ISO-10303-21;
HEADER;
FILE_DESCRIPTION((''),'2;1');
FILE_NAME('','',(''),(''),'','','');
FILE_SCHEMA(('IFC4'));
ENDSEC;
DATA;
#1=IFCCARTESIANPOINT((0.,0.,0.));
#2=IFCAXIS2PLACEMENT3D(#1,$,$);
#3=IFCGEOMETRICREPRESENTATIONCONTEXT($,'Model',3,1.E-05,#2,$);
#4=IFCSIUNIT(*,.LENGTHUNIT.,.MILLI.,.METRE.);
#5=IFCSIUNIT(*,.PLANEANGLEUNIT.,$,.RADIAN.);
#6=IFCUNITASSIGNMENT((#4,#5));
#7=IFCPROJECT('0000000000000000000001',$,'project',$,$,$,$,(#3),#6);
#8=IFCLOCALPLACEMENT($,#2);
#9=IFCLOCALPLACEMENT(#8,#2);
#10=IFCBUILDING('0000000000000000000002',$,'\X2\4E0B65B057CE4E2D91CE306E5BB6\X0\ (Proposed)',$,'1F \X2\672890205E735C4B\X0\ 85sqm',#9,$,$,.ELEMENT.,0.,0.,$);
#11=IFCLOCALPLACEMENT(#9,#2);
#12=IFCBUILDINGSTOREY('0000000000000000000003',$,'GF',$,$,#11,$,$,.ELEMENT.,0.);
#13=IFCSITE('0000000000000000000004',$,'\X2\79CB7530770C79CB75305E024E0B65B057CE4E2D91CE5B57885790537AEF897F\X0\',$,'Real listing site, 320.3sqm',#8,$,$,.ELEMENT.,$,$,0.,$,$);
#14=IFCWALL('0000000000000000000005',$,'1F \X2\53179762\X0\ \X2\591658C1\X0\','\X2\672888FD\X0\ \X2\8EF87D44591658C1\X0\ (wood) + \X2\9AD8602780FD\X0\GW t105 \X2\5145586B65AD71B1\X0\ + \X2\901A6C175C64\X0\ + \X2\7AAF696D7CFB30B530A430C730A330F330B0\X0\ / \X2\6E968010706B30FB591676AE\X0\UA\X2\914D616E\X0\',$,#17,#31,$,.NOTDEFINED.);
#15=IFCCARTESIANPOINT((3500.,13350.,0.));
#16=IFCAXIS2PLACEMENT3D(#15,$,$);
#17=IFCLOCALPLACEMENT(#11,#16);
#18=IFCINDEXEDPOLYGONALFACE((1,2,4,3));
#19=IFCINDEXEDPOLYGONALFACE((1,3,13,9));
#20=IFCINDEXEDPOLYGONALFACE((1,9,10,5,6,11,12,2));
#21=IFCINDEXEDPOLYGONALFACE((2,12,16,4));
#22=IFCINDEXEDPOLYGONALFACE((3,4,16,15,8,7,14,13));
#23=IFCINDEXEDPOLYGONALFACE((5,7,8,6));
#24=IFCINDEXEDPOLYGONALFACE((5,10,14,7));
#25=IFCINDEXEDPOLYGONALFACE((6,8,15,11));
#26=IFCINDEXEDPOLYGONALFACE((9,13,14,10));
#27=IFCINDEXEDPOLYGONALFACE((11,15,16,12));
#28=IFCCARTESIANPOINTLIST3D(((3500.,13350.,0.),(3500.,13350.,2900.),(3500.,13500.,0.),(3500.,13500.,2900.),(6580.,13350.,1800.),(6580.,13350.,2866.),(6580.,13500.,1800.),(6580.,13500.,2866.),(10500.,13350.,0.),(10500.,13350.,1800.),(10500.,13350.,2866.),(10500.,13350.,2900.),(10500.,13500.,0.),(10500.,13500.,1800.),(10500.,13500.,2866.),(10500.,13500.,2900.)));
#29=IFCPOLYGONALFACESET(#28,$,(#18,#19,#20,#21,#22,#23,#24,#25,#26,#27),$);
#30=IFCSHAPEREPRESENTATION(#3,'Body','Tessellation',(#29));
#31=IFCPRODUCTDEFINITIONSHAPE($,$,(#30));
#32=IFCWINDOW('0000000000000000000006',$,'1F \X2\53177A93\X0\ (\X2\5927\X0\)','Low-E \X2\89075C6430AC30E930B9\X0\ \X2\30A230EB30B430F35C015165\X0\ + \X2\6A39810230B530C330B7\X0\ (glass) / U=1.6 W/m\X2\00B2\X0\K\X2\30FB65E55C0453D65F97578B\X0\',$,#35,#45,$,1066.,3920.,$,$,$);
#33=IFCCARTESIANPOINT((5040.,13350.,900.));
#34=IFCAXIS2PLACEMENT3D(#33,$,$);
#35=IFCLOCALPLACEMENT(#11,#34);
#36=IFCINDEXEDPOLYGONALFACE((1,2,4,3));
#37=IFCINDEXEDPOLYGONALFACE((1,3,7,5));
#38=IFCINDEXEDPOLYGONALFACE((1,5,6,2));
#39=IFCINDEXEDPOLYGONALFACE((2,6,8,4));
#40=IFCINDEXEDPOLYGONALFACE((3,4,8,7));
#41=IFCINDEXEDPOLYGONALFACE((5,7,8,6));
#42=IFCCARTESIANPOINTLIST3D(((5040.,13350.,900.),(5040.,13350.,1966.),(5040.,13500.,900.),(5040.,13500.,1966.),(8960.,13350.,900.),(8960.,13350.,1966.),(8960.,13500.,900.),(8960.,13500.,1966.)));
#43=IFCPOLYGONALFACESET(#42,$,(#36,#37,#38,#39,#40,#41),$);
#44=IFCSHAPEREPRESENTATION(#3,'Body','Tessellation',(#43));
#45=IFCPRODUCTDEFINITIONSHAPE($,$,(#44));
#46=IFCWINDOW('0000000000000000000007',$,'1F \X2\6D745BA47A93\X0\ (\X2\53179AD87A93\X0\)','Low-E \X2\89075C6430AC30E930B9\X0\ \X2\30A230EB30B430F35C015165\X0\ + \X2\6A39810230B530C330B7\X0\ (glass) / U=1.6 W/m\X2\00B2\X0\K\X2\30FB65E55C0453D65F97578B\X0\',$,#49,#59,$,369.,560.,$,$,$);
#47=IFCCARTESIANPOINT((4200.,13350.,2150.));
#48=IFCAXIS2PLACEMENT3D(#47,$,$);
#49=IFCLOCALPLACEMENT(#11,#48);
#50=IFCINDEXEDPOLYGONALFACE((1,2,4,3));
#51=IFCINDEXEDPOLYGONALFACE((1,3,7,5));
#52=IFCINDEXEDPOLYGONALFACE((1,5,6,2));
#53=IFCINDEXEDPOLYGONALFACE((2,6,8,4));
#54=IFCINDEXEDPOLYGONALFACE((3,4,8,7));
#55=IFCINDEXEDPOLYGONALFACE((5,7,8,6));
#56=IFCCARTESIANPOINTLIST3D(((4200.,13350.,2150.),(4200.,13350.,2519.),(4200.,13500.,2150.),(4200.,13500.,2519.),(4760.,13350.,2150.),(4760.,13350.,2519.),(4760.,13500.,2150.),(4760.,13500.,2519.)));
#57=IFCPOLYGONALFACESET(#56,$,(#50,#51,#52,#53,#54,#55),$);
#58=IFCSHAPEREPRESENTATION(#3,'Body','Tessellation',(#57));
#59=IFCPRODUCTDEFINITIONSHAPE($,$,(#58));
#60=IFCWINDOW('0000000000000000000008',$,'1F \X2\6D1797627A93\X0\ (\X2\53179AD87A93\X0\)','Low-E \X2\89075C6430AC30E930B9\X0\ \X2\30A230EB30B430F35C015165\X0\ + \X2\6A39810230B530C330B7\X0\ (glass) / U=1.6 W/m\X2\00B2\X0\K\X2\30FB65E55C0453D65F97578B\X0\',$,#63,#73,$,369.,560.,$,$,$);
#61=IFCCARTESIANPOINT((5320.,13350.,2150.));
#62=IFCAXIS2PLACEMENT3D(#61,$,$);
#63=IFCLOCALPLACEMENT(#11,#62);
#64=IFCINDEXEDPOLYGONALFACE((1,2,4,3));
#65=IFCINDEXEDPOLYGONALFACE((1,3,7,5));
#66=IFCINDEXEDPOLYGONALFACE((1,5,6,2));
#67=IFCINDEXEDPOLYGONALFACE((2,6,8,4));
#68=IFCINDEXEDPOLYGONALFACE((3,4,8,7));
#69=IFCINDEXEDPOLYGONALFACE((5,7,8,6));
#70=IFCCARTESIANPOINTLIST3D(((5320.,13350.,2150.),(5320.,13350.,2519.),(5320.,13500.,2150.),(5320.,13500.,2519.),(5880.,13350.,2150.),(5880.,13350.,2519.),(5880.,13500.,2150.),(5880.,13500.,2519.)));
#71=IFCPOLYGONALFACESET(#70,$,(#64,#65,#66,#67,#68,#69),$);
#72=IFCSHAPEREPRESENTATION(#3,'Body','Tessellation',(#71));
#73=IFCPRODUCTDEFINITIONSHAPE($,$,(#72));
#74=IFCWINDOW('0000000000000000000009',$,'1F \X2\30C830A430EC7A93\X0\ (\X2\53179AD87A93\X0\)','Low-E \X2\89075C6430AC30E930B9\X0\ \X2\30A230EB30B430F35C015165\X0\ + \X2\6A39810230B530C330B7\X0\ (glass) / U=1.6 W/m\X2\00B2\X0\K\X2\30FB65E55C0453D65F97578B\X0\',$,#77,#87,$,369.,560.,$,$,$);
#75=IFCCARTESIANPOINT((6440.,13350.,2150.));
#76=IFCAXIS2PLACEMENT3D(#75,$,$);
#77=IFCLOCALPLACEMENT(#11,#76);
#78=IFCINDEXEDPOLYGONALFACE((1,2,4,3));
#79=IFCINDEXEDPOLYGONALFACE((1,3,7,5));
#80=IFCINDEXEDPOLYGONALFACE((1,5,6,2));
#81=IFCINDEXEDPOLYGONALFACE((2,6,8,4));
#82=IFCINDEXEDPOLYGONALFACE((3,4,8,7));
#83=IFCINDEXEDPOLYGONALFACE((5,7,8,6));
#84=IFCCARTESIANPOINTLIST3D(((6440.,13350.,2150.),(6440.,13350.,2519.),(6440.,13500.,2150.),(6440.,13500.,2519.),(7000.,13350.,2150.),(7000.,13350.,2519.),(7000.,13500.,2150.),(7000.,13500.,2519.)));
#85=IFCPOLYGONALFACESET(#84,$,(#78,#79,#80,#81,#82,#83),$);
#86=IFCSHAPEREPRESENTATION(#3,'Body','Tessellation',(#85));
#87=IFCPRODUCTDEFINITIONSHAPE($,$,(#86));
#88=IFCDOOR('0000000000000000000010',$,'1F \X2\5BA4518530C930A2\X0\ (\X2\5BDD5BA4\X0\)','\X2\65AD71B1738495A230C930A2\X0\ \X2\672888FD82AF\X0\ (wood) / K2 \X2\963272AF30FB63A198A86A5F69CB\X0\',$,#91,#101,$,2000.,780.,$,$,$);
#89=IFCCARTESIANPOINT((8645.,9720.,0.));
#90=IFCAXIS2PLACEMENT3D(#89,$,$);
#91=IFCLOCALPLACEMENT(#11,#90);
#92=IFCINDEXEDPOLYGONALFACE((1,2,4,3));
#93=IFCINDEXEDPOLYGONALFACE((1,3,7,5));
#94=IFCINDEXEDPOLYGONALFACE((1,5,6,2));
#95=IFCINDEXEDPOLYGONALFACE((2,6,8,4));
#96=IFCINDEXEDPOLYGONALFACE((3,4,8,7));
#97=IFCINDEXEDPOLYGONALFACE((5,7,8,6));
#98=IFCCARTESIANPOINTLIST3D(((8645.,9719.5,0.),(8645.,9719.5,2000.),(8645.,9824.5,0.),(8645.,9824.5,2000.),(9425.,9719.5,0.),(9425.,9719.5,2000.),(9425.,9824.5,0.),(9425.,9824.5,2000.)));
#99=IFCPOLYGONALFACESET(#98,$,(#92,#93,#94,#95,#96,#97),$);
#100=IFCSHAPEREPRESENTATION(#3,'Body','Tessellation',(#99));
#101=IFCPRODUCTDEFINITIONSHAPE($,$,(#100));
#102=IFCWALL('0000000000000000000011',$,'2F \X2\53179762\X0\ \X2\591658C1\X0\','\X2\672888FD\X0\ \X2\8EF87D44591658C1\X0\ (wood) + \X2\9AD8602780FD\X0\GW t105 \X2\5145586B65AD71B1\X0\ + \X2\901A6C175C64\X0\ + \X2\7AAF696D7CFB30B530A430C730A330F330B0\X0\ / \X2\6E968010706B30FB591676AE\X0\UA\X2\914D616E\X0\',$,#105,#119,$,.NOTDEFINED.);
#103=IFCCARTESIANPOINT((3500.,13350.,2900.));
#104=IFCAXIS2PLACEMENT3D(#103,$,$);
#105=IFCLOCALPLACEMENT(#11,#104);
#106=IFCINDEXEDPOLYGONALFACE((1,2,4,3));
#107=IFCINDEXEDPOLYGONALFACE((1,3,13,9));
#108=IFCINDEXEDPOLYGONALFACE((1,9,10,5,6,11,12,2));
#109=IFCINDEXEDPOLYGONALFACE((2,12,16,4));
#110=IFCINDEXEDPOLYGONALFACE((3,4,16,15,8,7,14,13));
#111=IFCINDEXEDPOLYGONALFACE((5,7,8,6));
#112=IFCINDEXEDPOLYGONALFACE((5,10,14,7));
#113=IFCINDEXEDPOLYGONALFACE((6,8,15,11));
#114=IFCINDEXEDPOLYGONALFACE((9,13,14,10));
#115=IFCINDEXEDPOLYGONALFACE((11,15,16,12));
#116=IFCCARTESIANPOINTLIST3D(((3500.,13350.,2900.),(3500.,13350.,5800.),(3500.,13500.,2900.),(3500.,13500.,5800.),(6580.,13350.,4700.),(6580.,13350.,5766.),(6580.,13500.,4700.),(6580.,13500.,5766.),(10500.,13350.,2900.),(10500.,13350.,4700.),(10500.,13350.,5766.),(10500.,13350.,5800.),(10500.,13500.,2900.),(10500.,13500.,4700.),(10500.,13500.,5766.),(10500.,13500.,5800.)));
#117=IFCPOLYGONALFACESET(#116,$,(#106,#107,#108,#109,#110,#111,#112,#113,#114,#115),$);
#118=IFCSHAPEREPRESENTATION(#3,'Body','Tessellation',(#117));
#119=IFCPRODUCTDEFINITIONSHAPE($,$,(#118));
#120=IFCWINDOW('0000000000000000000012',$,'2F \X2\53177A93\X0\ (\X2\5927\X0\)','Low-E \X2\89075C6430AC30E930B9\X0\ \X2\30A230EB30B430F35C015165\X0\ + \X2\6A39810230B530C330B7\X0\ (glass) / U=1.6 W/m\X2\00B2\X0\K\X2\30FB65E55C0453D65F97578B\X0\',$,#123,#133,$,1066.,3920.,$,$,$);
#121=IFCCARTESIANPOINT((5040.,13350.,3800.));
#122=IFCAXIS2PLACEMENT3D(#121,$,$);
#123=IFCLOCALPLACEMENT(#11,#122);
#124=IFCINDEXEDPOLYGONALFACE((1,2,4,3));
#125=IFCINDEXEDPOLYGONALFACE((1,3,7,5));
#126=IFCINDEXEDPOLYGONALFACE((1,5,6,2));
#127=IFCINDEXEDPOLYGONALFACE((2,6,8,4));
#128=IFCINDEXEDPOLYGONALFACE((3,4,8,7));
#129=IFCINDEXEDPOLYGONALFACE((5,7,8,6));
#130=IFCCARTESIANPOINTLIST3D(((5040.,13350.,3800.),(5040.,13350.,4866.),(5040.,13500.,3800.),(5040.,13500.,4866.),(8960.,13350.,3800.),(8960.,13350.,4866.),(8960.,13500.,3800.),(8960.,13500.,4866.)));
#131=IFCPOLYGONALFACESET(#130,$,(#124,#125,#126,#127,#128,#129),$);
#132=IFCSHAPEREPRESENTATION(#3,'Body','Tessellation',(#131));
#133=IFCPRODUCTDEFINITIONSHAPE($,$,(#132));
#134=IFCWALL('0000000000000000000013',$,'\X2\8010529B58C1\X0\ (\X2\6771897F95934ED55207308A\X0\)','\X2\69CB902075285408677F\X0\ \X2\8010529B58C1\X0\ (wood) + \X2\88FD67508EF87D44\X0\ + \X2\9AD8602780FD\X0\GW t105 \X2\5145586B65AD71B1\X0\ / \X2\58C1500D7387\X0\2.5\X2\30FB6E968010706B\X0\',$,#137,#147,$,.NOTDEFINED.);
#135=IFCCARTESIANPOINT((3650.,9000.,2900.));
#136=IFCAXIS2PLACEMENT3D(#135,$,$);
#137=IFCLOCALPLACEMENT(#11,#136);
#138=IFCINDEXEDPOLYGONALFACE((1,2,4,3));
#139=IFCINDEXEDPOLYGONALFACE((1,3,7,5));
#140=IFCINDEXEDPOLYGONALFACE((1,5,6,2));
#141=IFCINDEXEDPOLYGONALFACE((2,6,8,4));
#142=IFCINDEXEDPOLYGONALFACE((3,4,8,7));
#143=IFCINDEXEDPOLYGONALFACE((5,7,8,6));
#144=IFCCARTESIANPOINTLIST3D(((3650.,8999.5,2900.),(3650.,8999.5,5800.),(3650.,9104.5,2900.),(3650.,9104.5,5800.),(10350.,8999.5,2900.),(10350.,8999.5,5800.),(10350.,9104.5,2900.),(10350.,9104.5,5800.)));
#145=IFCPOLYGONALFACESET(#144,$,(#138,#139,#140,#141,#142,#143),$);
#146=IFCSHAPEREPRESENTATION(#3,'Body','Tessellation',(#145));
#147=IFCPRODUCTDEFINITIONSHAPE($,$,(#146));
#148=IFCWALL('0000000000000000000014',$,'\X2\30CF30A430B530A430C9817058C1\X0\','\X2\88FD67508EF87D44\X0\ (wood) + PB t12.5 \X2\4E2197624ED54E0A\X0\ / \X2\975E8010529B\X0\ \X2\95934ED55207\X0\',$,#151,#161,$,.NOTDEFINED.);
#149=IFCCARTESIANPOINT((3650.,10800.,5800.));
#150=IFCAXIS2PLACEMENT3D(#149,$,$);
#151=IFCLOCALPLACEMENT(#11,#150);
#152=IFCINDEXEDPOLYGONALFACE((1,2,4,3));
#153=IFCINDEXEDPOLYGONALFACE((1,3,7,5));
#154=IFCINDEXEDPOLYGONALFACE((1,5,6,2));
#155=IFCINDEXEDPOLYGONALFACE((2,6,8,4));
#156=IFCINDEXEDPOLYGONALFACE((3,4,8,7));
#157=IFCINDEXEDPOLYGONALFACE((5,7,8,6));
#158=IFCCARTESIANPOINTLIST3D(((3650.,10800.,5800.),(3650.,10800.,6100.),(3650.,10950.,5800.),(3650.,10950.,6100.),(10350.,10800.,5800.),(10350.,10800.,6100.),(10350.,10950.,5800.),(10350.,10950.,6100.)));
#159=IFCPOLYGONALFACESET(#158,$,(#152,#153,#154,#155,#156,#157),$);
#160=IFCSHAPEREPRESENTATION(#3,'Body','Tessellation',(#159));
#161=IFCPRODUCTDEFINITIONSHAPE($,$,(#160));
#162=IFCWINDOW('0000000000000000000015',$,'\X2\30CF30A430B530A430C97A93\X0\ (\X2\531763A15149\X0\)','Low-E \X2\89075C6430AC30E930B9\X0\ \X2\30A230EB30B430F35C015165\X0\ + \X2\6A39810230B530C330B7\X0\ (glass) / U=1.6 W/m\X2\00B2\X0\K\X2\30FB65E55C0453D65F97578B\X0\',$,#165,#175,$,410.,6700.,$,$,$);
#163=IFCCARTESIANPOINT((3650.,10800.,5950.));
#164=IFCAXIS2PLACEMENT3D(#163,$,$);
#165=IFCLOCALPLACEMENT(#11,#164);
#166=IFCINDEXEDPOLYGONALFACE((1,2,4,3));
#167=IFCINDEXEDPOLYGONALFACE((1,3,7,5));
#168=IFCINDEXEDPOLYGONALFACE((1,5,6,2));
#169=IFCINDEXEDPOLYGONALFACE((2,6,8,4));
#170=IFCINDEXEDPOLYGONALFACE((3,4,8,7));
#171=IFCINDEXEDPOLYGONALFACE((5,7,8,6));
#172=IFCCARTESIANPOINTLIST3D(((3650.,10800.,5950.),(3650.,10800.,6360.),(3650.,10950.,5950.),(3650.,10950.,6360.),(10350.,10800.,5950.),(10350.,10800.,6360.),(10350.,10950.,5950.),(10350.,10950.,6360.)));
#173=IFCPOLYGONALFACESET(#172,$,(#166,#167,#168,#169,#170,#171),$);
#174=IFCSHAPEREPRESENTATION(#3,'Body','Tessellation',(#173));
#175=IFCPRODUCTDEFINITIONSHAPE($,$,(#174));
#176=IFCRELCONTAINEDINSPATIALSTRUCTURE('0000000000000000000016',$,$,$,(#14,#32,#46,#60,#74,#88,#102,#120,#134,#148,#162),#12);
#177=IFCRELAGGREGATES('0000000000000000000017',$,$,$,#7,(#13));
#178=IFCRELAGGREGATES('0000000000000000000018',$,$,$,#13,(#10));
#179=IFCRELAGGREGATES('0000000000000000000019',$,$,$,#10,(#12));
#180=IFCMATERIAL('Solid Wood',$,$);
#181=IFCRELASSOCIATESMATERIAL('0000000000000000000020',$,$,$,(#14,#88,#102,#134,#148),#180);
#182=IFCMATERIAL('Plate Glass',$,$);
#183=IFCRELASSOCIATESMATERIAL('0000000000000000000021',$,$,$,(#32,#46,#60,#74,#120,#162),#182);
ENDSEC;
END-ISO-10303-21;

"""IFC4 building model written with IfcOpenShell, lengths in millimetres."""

from ifc_helpers import new_model, si_unit, frame, frame_2d, origin, place, context, project, spatial, rectangle, extrude, material, element, fill, save


model = new_model("IFC4")

# Units and contexts
model_context = context("Model", 3, precision=1e-05, world=origin())
ifc_project = project(units=[si_unit("LENGTHUNIT", "METRE", prefix="MILLI"), si_unit("PLANEANGLEUNIT", "RADIAN")], contexts=[model_context])

# Site, building, storey
site_placement = place(None, origin())
site = spatial("IfcSite", under=ifc_project, at=site_placement, Name="秋田県秋田市下新城中野字街道端西", ObjectType="Real listing site, 320.3sqm", CompositionType="ELEMENT", RefElevation=0.0)
building_placement = place(site_placement, origin())
building = spatial("IfcBuilding", under=site, at=building_placement, Name="下新城中野の家 (Proposed)", ObjectType="1F 木造平屋 85sqm", CompositionType="ELEMENT", ElevationOfRefHeight=0.0, ElevationOfTerrain=0.0)
storey_placement = place(building_placement, origin())
storey = spatial("IfcBuildingStorey", under=building, at=storey_placement, Name="GF", CompositionType="ELEMENT", Elevation=0.0)

# Wall, openings, windows
ifc_material_1 = material(Name="Solid Wood")
wall_1_placement = place(storey_placement, frame((3500.0, 13350.0, 0.0)))
wall_1 = element("IfcWall", 1, at=wall_1_placement, inside=storey, material=ifc_material_1, Name="1F 北面 外壁", Description="木製 軸組外壁 (wood) + 高性能GW t105 充填断熱 + 通気層 + 窯業系サイディング / 準耐火・外皮UA配慮", PredefinedType="NOTDEFINED", context=model_context, shape_type="SweptSolid", body=[
    extrude(rectangle(XDim=7000.0, YDim=150.0, at=frame_2d((3500.0, 75.0))), frame((3500.0, 13350.0, 0.0)), (0.0, 0.0, 1.0), 2900.0),
])
opening_1_placement = place(storey_placement, frame((5040.0, 13350.0, 900.0)))
opening_1 = element("IfcOpeningElement", 2, at=opening_1_placement, cuts=wall_1, PredefinedType="NOTDEFINED", context=model_context, shape_type="SweptSolid", body=[
    extrude(rectangle(XDim=3920.0, YDim=150.0, at=frame_2d((1960.0, 75.0))), frame((5040.0, 13350.0, 900.0)), (0.0, 0.0, 1.0), 1066.0),
])
opening_2_placement = place(storey_placement, frame((4200.0, 13350.0, 2150.0)))
opening_2 = element("IfcOpeningElement", 3, at=opening_2_placement, cuts=wall_1, PredefinedType="NOTDEFINED", context=model_context, shape_type="SweptSolid", body=[
    extrude(rectangle(XDim=560.0, YDim=150.0, at=frame_2d((280.0, 75.0))), frame((4200.0, 13350.0, 2150.0)), (0.0, 0.0, 1.0), 369.0),
])
opening_3_placement = place(storey_placement, frame((5320.0, 13350.0, 2150.0)))
opening_3 = element("IfcOpeningElement", 4, at=opening_3_placement, cuts=wall_1, PredefinedType="NOTDEFINED", context=model_context, shape_type="SweptSolid", body=[
    extrude(rectangle(XDim=560.0, YDim=150.0, at=frame_2d((280.0, 75.0))), frame((5320.0, 13350.0, 2150.0)), (0.0, 0.0, 1.0), 369.0),
])
opening_4_placement = place(storey_placement, frame((6440.0, 13350.0, 2150.0)))
opening_4 = element("IfcOpeningElement", 5, at=opening_4_placement, cuts=wall_1, PredefinedType="NOTDEFINED", context=model_context, shape_type="SweptSolid", body=[
    extrude(rectangle(XDim=560.0, YDim=150.0, at=frame_2d((280.0, 75.0))), frame((6440.0, 13350.0, 2150.0)), (0.0, 0.0, 1.0), 369.0),
])
ifc_material_2 = material(Name="Plate Glass")
window_1_placement = place(storey_placement, frame((5040.0, 13350.0, 900.0)))
window_1 = element("IfcWindow", 6, at=window_1_placement, inside=storey, material=ifc_material_2, Name="1F 北窓 (大)", Description="Low-E 複層ガラス アルゴン封入 + 樹脂サッシ (glass) / U=1.6 W/m²K・日射取得型", OverallHeight=1066.0, OverallWidth=3920.0, context=model_context, shape_type="SweptSolid", body=[
    extrude(rectangle(XDim=3920.0, YDim=150.0, at=frame_2d((1960.0, 75.0))), frame((5040.0, 13350.0, 900.0)), (0.0, 0.0, 1.0), 1066.0),
])
fill(opening_1, window_1)
window_2_placement = place(storey_placement, frame((4200.0, 13350.0, 2150.0)))
window_2 = element("IfcWindow", 7, at=window_2_placement, inside=storey, material=ifc_material_2, Name="1F 浴室窓 (北高窓)", Description="Low-E 複層ガラス アルゴン封入 + 樹脂サッシ (glass) / U=1.6 W/m²K・日射取得型", OverallHeight=369.0, OverallWidth=560.0, context=model_context, shape_type="SweptSolid", body=[
    extrude(rectangle(XDim=560.0, YDim=150.0, at=frame_2d((280.0, 75.0))), frame((4200.0, 13350.0, 2150.0)), (0.0, 0.0, 1.0), 369.0),
])
fill(opening_2, window_2)
window_3_placement = place(storey_placement, frame((5320.0, 13350.0, 2150.0)))
window_3 = element("IfcWindow", 8, at=window_3_placement, inside=storey, material=ifc_material_2, Name="1F 洗面窓 (北高窓)", Description="Low-E 複層ガラス アルゴン封入 + 樹脂サッシ (glass) / U=1.6 W/m²K・日射取得型", OverallHeight=369.0, OverallWidth=560.0, context=model_context, shape_type="SweptSolid", body=[
    extrude(rectangle(XDim=560.0, YDim=150.0, at=frame_2d((280.0, 75.0))), frame((5320.0, 13350.0, 2150.0)), (0.0, 0.0, 1.0), 369.0),
])
fill(opening_3, window_3)
window_4_placement = place(storey_placement, frame((6440.0, 13350.0, 2150.0)))
window_4 = element("IfcWindow", 9, at=window_4_placement, inside=storey, material=ifc_material_2, Name="1F トイレ窓 (北高窓)", Description="Low-E 複層ガラス アルゴン封入 + 樹脂サッシ (glass) / U=1.6 W/m²K・日射取得型", OverallHeight=369.0, OverallWidth=560.0, context=model_context, shape_type="SweptSolid", body=[
    extrude(rectangle(XDim=560.0, YDim=150.0, at=frame_2d((280.0, 75.0))), frame((6440.0, 13350.0, 2150.0)), (0.0, 0.0, 1.0), 369.0),
])
fill(opening_4, window_4)

# Door
door_1_placement = place(storey_placement, frame((8645.0, 9720.0, 0.0)))
element("IfcDoor", 10, at=door_1_placement, inside=storey, material=ifc_material_1, Name="1F 室内ドア (寝室)", Description="断熱玄関ドア 木製芯 (wood) / K2 防犯・採風機構", OverallHeight=2000.0, OverallWidth=780.0, context=model_context, shape_type="SweptSolid", body=[
    extrude(rectangle(XDim=780.0, YDim=105.0, at=frame_2d((390.0, 52.0))), frame((8645.0, 9720.0, 0.0)), (0.0, 0.0, 1.0), 2000.0),
])

# Wall, opening, window
wall_2_placement = place(storey_placement, frame((3500.0, 13350.0, 2900.0)))
wall_2 = element("IfcWall", 11, at=wall_2_placement, inside=storey, material=ifc_material_1, Name="2F 北面 外壁", Description="木製 軸組外壁 (wood) + 高性能GW t105 充填断熱 + 通気層 + 窯業系サイディング / 準耐火・外皮UA配慮", PredefinedType="NOTDEFINED", context=model_context, shape_type="SweptSolid", body=[
    extrude(rectangle(XDim=7000.0, YDim=150.0, at=frame_2d((3500.0, 75.0))), frame((3500.0, 13350.0, 2900.0)), (0.0, 0.0, 1.0), 2900.0),
])
opening_5_placement = place(storey_placement, frame((5040.0, 13350.0, 3800.0)))
opening_5 = element("IfcOpeningElement", 12, at=opening_5_placement, cuts=wall_2, PredefinedType="NOTDEFINED", context=model_context, shape_type="SweptSolid", body=[
    extrude(rectangle(XDim=3920.0, YDim=150.0, at=frame_2d((1960.0, 75.0))), frame((5040.0, 13350.0, 3800.0)), (0.0, 0.0, 1.0), 1066.0),
])
window_5_placement = place(storey_placement, frame((5040.0, 13350.0, 3800.0)))
window_5 = element("IfcWindow", 13, at=window_5_placement, inside=storey, material=ifc_material_2, Name="2F 北窓 (大)", Description="Low-E 複層ガラス アルゴン封入 + 樹脂サッシ (glass) / U=1.6 W/m²K・日射取得型", OverallHeight=1066.0, OverallWidth=3920.0, context=model_context, shape_type="SweptSolid", body=[
    extrude(rectangle(XDim=3920.0, YDim=150.0, at=frame_2d((1960.0, 75.0))), frame((5040.0, 13350.0, 3800.0)), (0.0, 0.0, 1.0), 1066.0),
])
fill(opening_5, window_5)

# Wall
wall_3_placement = place(storey_placement, frame((3650.0, 9000.0, 2900.0)))
element("IfcWall", 14, at=wall_3_placement, inside=storey, material=ifc_material_1, Name="耐力壁 (東西間仕切り)", Description="構造用合板 耐力壁 (wood) + 製材軸組 + 高性能GW t105 充填断熱 / 壁倍率2.5・準耐火", PredefinedType="NOTDEFINED", context=model_context, shape_type="SweptSolid", body=[
    extrude(rectangle(XDim=6700.0, YDim=105.0, at=frame_2d((3350.0, 52.0))), frame((3650.0, 9000.0, 2900.0)), (0.0, 0.0, 1.0), 2900.0),
])

# Wall, opening, window
wall_4_placement = place(storey_placement, frame((3650.0, 10800.0, 5800.0)))
wall_4 = element("IfcWall", 15, at=wall_4_placement, inside=storey, material=ifc_material_1, Name="ハイサイド腰壁", Description="製材軸組 (wood) + PB t12.5 両面仕上 / 非耐力 間仕切", PredefinedType="NOTDEFINED", context=model_context, shape_type="SweptSolid", body=[
    extrude(rectangle(XDim=6700.0, YDim=150.0, at=frame_2d((3350.0, 75.0))), frame((3650.0, 10800.0, 5800.0)), (0.0, 0.0, 1.0), 700.0),
])
opening_6_placement = place(storey_placement, frame((3650.0, 10800.0, 5950.0)))
opening_6 = element("IfcOpeningElement", 16, at=opening_6_placement, cuts=wall_4, PredefinedType="NOTDEFINED", context=model_context, shape_type="SweptSolid", body=[
    extrude(rectangle(XDim=6700.0, YDim=150.0, at=frame_2d((3350.0, 75.0))), frame((3650.0, 10800.0, 5950.0)), (0.0, 0.0, 1.0), 410.0),
])
window_6_placement = place(storey_placement, frame((3650.0, 10800.0, 5950.0)))
window_6 = element("IfcWindow", 17, at=window_6_placement, inside=storey, material=ifc_material_2, Name="ハイサイド窓 (北採光)", Description="Low-E 複層ガラス アルゴン封入 + 樹脂サッシ (glass) / U=1.6 W/m²K・日射取得型", OverallHeight=410.0, OverallWidth=6700.0, context=model_context, shape_type="SweptSolid", body=[
    extrude(rectangle(XDim=6700.0, YDim=150.0, at=frame_2d((3350.0, 75.0))), frame((3650.0, 10800.0, 5950.0)), (0.0, 0.0, 1.0), 410.0),
])
fill(opening_6, window_6)

save(model, "model.ifc")
